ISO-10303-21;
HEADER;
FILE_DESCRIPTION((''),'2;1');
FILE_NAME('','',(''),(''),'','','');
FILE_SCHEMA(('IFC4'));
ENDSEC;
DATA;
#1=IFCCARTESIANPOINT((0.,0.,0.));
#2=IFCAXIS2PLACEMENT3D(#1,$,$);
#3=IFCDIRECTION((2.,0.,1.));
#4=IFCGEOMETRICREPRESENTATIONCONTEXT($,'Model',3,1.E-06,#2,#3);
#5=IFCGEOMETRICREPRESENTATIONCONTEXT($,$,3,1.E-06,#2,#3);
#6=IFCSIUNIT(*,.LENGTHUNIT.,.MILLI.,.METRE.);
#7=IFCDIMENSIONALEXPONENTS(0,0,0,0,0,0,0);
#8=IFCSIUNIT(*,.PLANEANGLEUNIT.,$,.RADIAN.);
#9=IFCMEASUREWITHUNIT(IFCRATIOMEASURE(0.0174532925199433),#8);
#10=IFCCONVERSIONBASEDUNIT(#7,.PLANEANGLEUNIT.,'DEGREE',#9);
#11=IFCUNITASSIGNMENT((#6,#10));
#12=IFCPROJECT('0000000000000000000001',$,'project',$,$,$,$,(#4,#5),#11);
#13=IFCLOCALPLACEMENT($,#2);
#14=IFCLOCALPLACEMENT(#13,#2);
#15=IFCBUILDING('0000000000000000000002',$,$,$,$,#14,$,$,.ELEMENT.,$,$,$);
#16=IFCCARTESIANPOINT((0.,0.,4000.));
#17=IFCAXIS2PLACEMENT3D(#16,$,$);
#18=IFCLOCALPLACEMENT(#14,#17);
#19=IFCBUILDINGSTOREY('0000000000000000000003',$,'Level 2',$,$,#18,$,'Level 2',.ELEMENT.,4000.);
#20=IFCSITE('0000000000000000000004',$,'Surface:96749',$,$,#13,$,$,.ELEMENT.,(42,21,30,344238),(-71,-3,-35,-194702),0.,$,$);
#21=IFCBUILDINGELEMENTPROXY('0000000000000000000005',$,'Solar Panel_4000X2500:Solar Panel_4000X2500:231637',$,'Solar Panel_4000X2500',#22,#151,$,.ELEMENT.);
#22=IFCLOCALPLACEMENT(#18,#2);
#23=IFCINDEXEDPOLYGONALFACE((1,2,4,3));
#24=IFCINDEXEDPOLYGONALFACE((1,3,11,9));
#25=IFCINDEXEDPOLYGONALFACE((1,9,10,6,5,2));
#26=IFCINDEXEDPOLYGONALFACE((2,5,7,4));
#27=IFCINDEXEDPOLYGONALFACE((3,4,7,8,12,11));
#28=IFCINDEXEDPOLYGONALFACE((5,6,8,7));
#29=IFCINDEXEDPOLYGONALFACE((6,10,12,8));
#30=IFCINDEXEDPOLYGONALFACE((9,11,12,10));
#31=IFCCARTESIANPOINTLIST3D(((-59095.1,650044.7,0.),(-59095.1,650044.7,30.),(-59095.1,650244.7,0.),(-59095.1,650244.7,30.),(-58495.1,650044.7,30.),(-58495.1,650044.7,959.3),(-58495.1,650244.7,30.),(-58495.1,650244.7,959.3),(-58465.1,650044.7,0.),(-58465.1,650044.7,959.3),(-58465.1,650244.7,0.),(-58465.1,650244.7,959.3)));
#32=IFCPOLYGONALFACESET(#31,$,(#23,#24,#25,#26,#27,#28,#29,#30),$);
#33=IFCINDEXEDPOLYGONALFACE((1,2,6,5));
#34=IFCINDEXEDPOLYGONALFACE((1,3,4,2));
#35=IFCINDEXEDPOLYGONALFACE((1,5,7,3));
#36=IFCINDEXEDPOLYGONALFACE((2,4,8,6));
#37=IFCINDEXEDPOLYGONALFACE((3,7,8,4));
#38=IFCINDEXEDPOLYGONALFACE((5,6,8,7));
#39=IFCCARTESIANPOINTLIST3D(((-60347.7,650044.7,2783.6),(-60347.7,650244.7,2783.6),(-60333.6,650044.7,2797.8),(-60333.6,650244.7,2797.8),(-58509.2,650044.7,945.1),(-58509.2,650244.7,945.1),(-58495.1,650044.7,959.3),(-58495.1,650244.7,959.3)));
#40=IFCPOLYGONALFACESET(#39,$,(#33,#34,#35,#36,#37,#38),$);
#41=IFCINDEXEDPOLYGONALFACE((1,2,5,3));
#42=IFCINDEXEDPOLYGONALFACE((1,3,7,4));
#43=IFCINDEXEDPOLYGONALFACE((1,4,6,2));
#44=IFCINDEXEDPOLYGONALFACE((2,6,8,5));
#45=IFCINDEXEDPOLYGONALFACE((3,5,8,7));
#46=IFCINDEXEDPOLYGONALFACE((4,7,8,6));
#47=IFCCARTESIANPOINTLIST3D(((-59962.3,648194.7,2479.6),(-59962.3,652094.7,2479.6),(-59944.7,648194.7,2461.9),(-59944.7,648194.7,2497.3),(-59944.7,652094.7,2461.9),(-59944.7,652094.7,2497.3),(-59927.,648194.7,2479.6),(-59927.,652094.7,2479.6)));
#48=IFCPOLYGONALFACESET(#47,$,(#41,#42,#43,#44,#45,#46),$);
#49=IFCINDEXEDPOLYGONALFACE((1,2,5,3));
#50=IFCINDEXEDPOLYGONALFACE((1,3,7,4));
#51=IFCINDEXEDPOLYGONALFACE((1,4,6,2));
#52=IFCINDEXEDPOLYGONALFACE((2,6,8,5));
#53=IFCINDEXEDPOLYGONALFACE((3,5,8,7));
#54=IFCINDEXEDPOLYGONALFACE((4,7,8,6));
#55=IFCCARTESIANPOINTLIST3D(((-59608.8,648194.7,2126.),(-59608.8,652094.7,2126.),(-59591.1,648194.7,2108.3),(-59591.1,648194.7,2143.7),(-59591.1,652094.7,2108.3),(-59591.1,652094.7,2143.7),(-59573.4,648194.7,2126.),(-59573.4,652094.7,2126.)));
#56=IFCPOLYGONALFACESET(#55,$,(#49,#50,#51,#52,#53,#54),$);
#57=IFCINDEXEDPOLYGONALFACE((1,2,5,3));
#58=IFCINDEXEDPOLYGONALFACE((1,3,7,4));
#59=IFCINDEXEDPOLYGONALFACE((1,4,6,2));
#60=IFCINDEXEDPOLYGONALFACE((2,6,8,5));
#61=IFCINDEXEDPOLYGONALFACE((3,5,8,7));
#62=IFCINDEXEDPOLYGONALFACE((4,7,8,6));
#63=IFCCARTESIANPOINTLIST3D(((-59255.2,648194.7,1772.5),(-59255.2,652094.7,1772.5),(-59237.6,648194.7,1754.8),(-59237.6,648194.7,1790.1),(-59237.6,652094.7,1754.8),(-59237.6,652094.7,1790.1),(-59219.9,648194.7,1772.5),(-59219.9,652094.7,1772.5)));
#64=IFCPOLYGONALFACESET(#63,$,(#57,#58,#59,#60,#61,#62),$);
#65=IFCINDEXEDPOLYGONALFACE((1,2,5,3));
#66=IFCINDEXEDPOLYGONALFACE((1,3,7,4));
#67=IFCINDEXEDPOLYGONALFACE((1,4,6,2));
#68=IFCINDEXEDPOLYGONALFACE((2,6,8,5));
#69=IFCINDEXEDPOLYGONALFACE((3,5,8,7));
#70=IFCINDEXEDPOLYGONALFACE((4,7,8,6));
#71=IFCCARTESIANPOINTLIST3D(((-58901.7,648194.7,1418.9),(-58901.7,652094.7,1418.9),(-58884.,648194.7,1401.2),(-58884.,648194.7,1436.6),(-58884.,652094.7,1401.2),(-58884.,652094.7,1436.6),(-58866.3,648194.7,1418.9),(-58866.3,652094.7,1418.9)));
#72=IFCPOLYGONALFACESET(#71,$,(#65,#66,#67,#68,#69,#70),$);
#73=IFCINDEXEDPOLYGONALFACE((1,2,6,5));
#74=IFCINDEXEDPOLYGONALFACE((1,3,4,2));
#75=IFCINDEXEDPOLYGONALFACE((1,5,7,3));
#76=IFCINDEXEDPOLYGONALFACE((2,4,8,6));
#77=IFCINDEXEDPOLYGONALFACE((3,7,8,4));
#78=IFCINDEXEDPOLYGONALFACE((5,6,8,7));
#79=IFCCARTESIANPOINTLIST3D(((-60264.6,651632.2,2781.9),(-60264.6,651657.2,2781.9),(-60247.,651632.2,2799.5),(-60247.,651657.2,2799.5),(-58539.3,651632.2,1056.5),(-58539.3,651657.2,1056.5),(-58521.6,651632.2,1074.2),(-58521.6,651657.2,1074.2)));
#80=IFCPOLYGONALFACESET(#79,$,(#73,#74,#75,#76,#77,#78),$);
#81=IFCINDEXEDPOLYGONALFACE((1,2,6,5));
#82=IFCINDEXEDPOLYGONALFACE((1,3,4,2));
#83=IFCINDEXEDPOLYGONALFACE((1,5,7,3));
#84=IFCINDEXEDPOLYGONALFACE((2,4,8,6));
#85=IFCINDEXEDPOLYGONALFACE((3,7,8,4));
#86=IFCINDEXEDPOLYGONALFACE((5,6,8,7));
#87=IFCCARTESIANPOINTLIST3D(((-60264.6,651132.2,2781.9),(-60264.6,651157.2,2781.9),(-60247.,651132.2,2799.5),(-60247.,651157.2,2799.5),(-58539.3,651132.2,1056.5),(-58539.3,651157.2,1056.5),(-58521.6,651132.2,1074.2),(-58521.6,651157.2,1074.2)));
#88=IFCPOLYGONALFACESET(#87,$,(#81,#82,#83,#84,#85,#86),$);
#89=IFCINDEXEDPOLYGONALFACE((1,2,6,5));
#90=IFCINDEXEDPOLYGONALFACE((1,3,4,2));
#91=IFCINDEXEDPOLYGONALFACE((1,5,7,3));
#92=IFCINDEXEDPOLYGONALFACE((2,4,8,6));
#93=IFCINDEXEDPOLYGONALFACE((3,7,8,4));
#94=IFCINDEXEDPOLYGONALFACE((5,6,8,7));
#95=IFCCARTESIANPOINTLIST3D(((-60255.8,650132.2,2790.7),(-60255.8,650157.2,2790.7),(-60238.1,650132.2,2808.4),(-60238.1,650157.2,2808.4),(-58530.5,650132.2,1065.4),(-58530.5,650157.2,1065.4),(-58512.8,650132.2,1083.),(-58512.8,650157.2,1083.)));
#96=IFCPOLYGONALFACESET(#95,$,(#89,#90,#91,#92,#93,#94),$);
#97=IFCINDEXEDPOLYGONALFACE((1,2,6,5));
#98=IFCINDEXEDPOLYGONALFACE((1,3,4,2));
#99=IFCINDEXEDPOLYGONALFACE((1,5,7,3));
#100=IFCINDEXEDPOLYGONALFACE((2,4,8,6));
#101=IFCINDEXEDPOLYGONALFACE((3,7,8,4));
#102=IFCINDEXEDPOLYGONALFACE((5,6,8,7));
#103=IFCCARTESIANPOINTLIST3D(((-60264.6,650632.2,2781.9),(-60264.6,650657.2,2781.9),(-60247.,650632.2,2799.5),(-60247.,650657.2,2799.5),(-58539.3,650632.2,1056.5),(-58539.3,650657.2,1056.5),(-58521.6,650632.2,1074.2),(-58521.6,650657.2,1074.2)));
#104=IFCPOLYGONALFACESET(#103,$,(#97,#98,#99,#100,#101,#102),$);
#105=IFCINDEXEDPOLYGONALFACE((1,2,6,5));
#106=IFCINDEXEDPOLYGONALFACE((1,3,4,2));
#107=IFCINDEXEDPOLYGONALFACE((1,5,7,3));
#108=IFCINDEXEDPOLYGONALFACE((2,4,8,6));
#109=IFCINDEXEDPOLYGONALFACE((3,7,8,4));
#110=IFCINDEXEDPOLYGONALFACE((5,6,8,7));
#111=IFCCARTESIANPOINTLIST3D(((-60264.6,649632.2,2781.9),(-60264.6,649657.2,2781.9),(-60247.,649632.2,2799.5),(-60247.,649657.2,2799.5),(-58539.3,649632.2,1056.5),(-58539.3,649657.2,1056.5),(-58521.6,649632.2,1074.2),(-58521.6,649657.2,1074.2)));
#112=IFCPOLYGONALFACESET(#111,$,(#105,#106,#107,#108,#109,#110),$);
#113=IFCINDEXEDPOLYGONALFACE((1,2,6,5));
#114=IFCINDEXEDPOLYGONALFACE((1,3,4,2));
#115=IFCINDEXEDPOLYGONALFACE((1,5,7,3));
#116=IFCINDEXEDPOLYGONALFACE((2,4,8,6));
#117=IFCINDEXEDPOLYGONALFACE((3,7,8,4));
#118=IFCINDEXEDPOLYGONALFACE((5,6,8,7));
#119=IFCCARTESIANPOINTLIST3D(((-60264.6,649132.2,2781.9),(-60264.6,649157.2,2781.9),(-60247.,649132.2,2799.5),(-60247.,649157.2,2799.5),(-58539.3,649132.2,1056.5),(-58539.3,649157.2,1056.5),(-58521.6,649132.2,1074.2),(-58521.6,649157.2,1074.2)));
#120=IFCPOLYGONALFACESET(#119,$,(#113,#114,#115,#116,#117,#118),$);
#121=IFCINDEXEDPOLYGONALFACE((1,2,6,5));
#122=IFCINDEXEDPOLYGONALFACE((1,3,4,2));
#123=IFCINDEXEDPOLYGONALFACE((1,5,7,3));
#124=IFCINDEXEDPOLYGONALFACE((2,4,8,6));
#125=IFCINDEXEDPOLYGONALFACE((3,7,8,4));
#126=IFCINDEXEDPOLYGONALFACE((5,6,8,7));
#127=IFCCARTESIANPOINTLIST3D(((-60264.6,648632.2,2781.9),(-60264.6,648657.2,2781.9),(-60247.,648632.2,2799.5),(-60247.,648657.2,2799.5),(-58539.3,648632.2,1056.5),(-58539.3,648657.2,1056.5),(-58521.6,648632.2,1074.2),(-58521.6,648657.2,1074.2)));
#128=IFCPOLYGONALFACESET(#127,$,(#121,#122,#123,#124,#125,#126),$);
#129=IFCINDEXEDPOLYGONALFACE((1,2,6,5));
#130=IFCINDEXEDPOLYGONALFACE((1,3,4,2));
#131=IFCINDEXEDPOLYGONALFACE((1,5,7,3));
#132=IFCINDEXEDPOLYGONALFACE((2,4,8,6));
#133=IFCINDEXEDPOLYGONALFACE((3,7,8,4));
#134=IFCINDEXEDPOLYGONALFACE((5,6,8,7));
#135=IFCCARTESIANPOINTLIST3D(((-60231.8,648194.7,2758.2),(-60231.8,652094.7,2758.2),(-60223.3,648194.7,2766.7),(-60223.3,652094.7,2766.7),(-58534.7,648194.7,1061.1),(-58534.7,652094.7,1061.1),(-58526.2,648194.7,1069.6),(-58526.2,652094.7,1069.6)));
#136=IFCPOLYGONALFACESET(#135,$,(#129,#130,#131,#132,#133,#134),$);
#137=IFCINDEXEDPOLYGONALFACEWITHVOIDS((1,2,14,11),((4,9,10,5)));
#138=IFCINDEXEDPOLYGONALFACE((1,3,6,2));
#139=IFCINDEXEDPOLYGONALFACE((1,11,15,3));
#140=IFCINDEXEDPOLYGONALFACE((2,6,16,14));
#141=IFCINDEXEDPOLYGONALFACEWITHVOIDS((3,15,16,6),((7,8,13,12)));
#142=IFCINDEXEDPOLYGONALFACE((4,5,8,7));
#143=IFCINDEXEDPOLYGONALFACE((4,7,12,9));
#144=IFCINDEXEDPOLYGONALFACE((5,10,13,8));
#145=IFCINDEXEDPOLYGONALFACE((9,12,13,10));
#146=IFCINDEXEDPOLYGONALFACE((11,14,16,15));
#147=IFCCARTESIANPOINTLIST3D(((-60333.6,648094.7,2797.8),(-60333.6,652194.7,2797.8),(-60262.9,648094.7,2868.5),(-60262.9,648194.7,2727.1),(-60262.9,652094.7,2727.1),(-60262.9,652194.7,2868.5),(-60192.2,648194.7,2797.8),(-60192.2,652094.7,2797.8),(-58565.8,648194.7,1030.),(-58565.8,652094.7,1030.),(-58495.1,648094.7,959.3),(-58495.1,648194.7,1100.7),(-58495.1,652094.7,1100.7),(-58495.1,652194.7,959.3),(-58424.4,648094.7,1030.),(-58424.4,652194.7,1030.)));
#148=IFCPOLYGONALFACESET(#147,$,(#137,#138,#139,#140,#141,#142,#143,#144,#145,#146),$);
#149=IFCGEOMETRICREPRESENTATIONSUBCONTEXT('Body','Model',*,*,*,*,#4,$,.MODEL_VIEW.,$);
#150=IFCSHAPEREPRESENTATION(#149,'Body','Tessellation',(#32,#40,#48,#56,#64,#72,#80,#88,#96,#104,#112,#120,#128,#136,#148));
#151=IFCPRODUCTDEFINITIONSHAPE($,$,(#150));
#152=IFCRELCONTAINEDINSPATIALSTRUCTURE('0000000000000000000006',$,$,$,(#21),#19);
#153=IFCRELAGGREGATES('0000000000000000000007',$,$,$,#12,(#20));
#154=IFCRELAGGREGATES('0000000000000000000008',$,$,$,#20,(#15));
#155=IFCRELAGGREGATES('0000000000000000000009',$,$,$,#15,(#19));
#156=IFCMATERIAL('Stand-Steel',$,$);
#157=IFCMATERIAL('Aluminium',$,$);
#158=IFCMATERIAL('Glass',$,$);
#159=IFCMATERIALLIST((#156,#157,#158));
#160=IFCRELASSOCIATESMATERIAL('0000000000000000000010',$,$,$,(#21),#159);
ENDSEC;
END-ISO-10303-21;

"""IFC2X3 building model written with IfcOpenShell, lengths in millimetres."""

from ifc_helpers import new_model, entity, si_unit, converted_unit, direction, frame, frame_2d, origin, origin_2d_with_axis, place, context, subcontext, project, spatial, polyline, rectangle, outline, extrude, source, transform, mapped, material, material_list, element, save


model = new_model("IFC2X3")

# Units and contexts
model_context = context("Model", 3, precision=1e-06, world=origin(), true_north=direction((2.0, 0.0, 1.0)))
context_of_model = context(None, 3, precision=1e-06, world=origin(), true_north=direction((2.0, 0.0, 1.0)))
body_context = subcontext(model_context, "Body", "Model", "MODEL_VIEW")
ifc_project = project(units=[si_unit("LENGTHUNIT", "METRE", prefix="MILLI"), converted_unit("PLANEANGLEUNIT", "DEGREE", entity("IfcRatioMeasure", 0.0174532925199433), si_unit("PLANEANGLEUNIT", "RADIAN"), dimensions=[0, 0, 0, 0, 0, 0, 0])], contexts=[model_context, context_of_model])

# Site, building, storey
site_placement = place(None, origin())
site = spatial("IfcSite", under=ifc_project, at=site_placement, Name="Surface:96749", CompositionType="ELEMENT", RefLatitude=(42, 21, 30, 344238), RefLongitude=(-71, -3, -35, -194702), RefElevation=0.0)
building_placement = place(site_placement, origin())
building = spatial("IfcBuilding", under=site, at=building_placement, CompositionType="ELEMENT")
storey_placement = place(building_placement, frame((0.0, 0.0, 4000.0)))
storey = spatial("IfcBuildingStorey", under=building, at=storey_placement, Name="Level 2", LongName="Level 2", CompositionType="ELEMENT", Elevation=4000.0)

# Building element proxy
ifc_material_1 = material(Name="Stand-Steel")
ifc_material_2 = material(Name="Aluminium")
ifc_material_3 = material(Name="Glass")
shared_shape = source(origin(), body_context, "Body", "SweptSolid", [
    extrude(outline(polyline([(-629.5, -220.0), (329.8, -220.0), (329.8, 410.0), (299.8, 410.0), (299.8, -190.0), (-629.5, -190.0), (-629.5, -220.0)])), frame((-190.0, -100.0, 299.8), z_axis=(0.0, 1.0, 0.0), x_axis=(0.0, 0.0, -1.0)), (0.0, 0.0, 1.0), 200.0),
    extrude(rectangle(XDim=20.0, YDim=200.0, at=frame_2d((0.0, 0.0), x_axis=(0.0, 1.0))), frame((-7.1, 0.0, 922.2), z_axis=(-0.707107, 0.0, 0.707107), x_axis=(0.0, 1.0, 0.0)), (0.0, 0.0, 1.0), 2600.0),
    extrude(rectangle(XDim=25.0, YDim=25.0, at=frame_2d((0.0, 0.0), x_axis=(1.0, 0.0))), frame((-1449.6, -1950.0, 2449.6), z_axis=(0.0, 1.0, 0.0), x_axis=(-0.707107, 0.0, -0.707107)), (0.0, 0.0, 1.0), 3900.0),
    extrude(rectangle(XDim=25.0, YDim=25.0, at=origin_2d_with_axis()), frame((-1096.0, -1950.0, 2096.0), z_axis=(0.0, 1.0, 0.0), x_axis=(-0.707107, 0.0, -0.707107)), (0.0, 0.0, 1.0), 3900.0),
    extrude(rectangle(XDim=25.0, YDim=25.0, at=origin_2d_with_axis()), frame((-742.5, -1950.0, 1742.5), z_axis=(0.0, 1.0, 0.0), x_axis=(-0.707107, 0.0, -0.707107)), (0.0, 0.0, 1.0), 3900.0),
    extrude(rectangle(XDim=25.0, YDim=25.0, at=frame_2d((0.0, 0.0), x_axis=(1.0, 0.0))), frame((-388.9, -1950.0, 1388.9), z_axis=(0.0, 1.0, 0.0), x_axis=(-0.707107, 0.0, -0.707107)), (0.0, 0.0, 1.0), 3900.0),
    extrude(rectangle(XDim=25.0, YDim=25.0, at=frame_2d((0.0, 0.0), x_axis=(0.0, 1.0))), frame((-35.4, 1500.0, 1035.4), z_axis=(-0.707107, 0.0, 0.707107), x_axis=(0.0, 1.0, 0.0)), (0.0, 0.0, 1.0), 2440.0),
    extrude(rectangle(XDim=25.0, YDim=25.0, at=frame_2d((0.0, 0.0), x_axis=(0.0, 1.0))), frame((-35.4, 1000.0, 1035.4), z_axis=(-0.707107, 0.0, 0.707107), x_axis=(0.0, 1.0, 0.0)), (0.0, 0.0, 1.0), 2440.0),
    extrude(rectangle(XDim=25.0, YDim=25.0, at=frame_2d((0.0, 0.0), x_axis=(0.0, 1.0))), frame((-26.5, 0.0, 1044.2), z_axis=(-0.707107, 0.0, 0.707107), x_axis=(0.0, -1.0, 0.0)), (0.0, 0.0, 1.0), 2440.0),
    extrude(rectangle(XDim=25.0, YDim=25.0, at=frame_2d((0.0, 0.0), x_axis=(0.0, 1.0))), frame((-35.4, 500.0, 1035.4), z_axis=(-0.707107, 0.0, 0.707107), x_axis=(0.0, 1.0, 0.0)), (0.0, 0.0, 1.0), 2440.0),
    extrude(rectangle(XDim=25.0, YDim=25.0, at=frame_2d((0.0, 0.0), x_axis=(0.0, 1.0))), frame((-35.4, -500.0, 1035.4), z_axis=(-0.707107, 0.0, 0.707107), x_axis=(0.0, 1.0, 0.0)), (0.0, 0.0, 1.0), 2440.0),
    extrude(rectangle(XDim=25.0, YDim=25.0, at=frame_2d((0.0, 0.0), x_axis=(0.0, 1.0))), frame((-35.4, -1000.0, 1035.4), z_axis=(-0.707107, 0.0, 0.707107), x_axis=(0.0, 1.0, 0.0)), (0.0, 0.0, 1.0), 2440.0),
    extrude(rectangle(XDim=25.0, YDim=25.0, at=frame_2d((0.0, 0.0), x_axis=(0.0, 1.0))), frame((-35.4, -1500.0, 1035.4), z_axis=(-0.707107, 0.0, 0.707107), x_axis=(0.0, 1.0, 0.0)), (0.0, 0.0, 1.0), 2440.0),
    extrude(rectangle(XDim=2400.0, YDim=12.0, at=frame_2d((0.0, 0.0), x_axis=(1.0, 0.0))), frame((-883.9, -1950.0, 1883.9), z_axis=(0.0, 1.0, 0.0), x_axis=(0.707107, 0.0, -0.707107)), (0.0, 0.0, 1.0), 3900.0),
    extrude(outline(polyline([(-2050.0, -1300.0), (2050.0, -1300.0), (2050.0, 1300.0), (-2050.0, 1300.0), (-2050.0, -1300.0)]), holes=[polyline([(1950.0, -1200.0), (-1950.0, -1200.0), (-1950.0, 1200.0), (1950.0, 1200.0), (1950.0, -1200.0)])]), frame((-919.2, 0.0, 1848.5), z_axis=(0.707107, 0.0, 0.707107), x_axis=(0.0, 1.0, 0.0)), (0.0, 0.0, 1.0), 100.0),
])
ifc_material_list_1 = material_list([ifc_material_1, ifc_material_2, ifc_material_3])
proxy_1_placement = place(storey_placement, frame((-58495.1, 650144.7, 30.0)))
element("IfcBuildingElementProxy", 1, at=proxy_1_placement, inside=storey, material=ifc_material_list_1, Name="Solar Panel_4000X2500:Solar Panel_4000X2500:231637", ObjectType="Solar Panel_4000X2500", CompositionType="ELEMENT", context=body_context, shape_type="MappedRepresentation", body=[
    mapped(shared_shape, transform((0.0, 0.0, 0.0), scale=1.0)),
])

save(model, "model.ifc")
